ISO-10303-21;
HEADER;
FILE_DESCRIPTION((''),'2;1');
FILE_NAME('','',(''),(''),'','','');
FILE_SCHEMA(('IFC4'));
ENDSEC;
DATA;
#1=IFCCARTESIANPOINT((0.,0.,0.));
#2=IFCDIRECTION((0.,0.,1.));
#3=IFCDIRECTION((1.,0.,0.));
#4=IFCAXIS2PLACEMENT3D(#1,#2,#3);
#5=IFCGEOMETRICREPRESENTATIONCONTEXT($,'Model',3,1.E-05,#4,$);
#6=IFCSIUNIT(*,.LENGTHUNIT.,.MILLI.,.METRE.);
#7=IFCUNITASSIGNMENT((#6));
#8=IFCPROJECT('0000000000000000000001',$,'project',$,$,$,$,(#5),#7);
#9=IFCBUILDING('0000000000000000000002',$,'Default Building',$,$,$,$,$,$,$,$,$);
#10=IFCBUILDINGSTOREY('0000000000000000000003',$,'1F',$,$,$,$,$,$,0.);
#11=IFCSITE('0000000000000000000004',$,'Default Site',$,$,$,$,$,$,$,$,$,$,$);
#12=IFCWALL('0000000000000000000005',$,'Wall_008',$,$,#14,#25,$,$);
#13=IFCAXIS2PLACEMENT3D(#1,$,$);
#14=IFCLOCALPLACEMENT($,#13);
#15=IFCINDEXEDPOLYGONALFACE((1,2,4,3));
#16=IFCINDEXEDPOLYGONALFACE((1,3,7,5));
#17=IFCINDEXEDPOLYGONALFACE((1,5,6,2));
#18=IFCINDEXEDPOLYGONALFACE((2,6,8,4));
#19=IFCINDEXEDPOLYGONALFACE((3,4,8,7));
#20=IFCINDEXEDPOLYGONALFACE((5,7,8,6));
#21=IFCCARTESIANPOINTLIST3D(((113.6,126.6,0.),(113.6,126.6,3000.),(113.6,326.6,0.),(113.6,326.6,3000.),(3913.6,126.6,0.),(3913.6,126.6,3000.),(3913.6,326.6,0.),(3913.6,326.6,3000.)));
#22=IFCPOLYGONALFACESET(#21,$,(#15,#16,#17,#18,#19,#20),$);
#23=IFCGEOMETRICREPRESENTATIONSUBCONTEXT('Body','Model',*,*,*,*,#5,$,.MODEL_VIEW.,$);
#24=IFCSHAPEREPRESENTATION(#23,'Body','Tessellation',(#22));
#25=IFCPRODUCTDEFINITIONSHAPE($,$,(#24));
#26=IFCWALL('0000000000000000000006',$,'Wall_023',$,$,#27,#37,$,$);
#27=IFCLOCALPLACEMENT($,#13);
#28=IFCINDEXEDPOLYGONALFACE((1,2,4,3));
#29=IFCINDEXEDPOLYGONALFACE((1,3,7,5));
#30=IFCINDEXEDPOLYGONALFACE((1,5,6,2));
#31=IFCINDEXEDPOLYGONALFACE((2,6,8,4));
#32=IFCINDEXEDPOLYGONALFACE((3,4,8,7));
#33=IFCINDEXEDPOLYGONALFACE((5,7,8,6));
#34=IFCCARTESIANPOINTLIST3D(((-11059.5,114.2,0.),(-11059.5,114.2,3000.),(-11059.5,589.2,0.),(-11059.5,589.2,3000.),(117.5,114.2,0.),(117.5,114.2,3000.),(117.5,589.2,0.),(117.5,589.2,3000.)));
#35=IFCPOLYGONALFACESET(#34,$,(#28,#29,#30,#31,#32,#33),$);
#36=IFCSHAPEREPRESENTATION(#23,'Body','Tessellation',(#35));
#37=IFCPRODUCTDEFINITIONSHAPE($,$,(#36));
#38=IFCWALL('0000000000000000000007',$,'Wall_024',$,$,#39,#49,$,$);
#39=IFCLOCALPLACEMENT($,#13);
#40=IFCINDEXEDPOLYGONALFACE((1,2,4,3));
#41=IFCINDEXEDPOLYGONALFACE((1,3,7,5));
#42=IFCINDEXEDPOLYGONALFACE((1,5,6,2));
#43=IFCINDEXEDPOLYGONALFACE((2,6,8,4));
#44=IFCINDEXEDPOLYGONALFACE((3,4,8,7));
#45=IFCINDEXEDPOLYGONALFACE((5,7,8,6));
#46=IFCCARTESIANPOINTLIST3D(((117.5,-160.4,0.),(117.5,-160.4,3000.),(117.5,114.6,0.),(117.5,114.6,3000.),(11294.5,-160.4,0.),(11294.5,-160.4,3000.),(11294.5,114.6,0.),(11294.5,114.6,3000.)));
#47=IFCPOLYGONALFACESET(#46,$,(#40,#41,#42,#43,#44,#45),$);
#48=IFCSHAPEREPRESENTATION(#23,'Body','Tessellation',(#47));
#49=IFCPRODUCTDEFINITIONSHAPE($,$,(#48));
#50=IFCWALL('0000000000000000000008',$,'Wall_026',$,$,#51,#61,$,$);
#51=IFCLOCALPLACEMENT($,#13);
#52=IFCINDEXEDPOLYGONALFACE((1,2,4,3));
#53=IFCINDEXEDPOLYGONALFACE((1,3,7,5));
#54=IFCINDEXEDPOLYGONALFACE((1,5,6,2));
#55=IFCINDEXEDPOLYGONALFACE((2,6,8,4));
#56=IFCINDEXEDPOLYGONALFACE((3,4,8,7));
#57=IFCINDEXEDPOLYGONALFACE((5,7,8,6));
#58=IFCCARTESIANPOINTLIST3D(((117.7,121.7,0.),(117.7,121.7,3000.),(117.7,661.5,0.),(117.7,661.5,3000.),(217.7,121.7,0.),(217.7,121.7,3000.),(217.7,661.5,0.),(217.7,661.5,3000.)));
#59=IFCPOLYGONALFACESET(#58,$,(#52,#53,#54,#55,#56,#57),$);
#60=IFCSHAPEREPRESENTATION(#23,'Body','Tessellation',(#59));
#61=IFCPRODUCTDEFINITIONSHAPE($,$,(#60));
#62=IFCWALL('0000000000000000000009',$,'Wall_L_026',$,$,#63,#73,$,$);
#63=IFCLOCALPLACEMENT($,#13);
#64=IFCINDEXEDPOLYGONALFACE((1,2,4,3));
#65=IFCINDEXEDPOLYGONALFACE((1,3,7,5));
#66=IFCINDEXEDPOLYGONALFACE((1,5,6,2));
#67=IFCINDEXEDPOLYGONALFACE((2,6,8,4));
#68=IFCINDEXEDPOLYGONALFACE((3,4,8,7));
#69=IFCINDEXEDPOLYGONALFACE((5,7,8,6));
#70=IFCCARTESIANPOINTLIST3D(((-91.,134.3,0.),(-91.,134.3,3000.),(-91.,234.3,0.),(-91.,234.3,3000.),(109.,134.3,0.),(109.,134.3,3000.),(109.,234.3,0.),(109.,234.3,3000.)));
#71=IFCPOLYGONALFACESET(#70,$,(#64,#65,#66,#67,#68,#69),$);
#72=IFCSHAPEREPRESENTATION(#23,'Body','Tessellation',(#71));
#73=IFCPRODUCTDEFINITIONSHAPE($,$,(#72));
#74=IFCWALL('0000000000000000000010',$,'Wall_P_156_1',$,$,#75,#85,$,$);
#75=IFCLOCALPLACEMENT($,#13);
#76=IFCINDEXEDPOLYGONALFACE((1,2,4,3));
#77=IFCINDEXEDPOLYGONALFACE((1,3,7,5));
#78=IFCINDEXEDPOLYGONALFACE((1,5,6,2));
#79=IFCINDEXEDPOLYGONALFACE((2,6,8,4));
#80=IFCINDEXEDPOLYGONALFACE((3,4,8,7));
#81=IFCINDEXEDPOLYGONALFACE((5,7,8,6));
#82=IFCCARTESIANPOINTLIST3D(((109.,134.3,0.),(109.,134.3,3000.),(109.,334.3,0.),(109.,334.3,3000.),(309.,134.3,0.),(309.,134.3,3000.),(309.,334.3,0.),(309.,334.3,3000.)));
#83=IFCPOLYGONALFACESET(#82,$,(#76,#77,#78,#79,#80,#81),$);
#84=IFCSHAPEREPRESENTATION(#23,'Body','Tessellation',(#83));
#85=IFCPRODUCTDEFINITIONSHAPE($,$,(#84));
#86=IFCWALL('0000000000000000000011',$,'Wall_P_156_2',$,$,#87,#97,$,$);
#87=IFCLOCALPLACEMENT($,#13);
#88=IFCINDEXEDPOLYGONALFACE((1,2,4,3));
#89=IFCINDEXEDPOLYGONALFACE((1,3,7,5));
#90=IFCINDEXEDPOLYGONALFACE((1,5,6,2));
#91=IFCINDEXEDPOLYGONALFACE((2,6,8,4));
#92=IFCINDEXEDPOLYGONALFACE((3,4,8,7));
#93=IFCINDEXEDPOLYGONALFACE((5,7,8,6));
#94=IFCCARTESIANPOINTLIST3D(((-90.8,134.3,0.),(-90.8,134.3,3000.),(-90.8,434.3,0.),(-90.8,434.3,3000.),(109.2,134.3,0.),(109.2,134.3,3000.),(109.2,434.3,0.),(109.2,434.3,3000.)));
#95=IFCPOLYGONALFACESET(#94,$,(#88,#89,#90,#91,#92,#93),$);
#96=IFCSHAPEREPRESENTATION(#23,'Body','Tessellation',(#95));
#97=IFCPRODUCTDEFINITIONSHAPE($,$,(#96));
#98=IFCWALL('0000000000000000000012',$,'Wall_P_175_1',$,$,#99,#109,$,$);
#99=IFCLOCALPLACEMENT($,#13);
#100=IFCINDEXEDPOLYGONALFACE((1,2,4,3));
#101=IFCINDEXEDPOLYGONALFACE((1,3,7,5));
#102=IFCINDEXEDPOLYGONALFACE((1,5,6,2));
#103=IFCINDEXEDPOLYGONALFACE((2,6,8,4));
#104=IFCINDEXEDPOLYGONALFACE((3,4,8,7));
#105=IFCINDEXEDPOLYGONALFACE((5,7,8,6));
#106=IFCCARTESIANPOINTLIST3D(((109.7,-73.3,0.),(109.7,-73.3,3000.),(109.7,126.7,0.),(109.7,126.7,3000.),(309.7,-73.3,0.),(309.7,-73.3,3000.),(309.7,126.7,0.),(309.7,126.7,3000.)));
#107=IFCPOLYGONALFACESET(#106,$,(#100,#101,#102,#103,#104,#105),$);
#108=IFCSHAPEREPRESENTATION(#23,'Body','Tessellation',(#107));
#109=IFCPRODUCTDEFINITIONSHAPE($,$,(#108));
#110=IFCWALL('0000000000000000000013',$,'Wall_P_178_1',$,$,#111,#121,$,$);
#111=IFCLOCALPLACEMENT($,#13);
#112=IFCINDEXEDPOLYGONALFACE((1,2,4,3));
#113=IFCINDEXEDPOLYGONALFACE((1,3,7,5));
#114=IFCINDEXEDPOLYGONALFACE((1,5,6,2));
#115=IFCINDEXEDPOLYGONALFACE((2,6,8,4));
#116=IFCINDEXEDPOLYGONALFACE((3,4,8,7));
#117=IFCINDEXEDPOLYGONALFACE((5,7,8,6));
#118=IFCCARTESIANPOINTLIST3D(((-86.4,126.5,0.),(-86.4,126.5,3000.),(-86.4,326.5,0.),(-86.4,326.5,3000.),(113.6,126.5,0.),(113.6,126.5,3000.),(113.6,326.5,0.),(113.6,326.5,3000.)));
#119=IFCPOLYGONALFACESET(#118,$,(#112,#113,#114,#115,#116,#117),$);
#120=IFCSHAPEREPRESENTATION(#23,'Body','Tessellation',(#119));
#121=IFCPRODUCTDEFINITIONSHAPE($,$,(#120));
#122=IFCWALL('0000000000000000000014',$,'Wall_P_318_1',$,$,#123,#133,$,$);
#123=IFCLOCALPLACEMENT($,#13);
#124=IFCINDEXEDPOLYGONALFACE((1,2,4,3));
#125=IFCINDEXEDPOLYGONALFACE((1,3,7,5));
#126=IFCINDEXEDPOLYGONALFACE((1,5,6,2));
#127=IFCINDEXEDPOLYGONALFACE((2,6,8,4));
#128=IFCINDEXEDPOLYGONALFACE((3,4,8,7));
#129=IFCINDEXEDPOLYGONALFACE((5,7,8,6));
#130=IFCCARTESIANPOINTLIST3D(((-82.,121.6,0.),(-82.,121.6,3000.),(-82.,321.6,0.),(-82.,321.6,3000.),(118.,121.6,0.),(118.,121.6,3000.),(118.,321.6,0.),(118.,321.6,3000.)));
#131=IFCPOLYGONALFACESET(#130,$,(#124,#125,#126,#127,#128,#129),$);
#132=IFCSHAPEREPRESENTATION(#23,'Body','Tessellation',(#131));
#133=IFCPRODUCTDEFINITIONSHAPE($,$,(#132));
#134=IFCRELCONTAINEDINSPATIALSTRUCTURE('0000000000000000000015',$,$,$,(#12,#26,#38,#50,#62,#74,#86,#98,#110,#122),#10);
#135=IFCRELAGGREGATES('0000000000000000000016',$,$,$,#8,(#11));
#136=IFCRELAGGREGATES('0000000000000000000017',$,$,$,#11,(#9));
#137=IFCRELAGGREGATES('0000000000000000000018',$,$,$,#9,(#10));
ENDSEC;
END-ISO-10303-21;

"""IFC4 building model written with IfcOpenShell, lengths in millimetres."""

from ifc_helpers import new_model, si_unit, frame, origin_with_axes, place, context, subcontext, project, spatial, indexed_curve, outline, extrude, element, save


model = new_model("IFC4")

# Units and contexts
model_context = context("Model", 3, precision=1e-05, world=origin_with_axes())
body_context = subcontext(model_context, "Body", "Model", "MODEL_VIEW")
ifc_project = project(units=[si_unit("LENGTHUNIT", "METRE", prefix="MILLI")], contexts=[model_context])

# Site, building, storey
site = spatial("IfcSite", under=ifc_project, Name="Default Site")
building = spatial("IfcBuilding", under=site, Name="Default Building")
storey = spatial("IfcBuildingStorey", under=building, Name="1F", Elevation=0.0)

# Walls
wall_1_placement = place(None, frame((113.6, 126.6, 0.0), z_axis=(0.0, 0.0, 1.0), x_axis=(1.0, 0.0, 0.0)))
element("IfcWall", 1, at=wall_1_placement, inside=storey, Name="Wall_008", context=body_context, shape_type="SweptSolid", body=[
    extrude(outline(indexed_curve([(0.0, 0.0), (0.0, 200.0), (3800.0, 200.0), (3800.0, 0.0), (0.0, 0.0)], self_intersect=False)), origin_with_axes(), (0.0, 0.0, 1.0), 3000.0),
])
wall_2_placement = place(None, frame((117.5, 114.2, 0.0), z_axis=(0.0, 0.0, 1.0), x_axis=(0.0, 1.0, 0.0)))
element("IfcWall", 2, at=wall_2_placement, inside=storey, Name="Wall_023", context=body_context, shape_type="SweptSolid", body=[
    extrude(outline(indexed_curve([(0.0, 0.0), (0.0, 11177.0), (475.0, 11177.0), (475.0, 0.0), (0.0, 0.0)], self_intersect=False)), origin_with_axes(), (0.0, 0.0, 1.0), 3000.0),
])
wall_3_placement = place(None, frame((117.5, 114.6, 0.0), z_axis=(0.0, 0.0, 1.0), x_axis=(0.0, -1.0, 0.0)))
element("IfcWall", 3, at=wall_3_placement, inside=storey, Name="Wall_024", context=body_context, shape_type="SweptSolid", body=[
    extrude(outline(indexed_curve([(0.0, 0.0), (0.0, 11177.0), (275.0, 11177.0), (275.0, 0.0), (0.0, 0.0)], self_intersect=False)), origin_with_axes(), (0.0, 0.0, 1.0), 3000.0),
])
wall_4_placement = place(None, frame((117.7, 121.7, 0.0), z_axis=(0.0, 0.0, 1.0), x_axis=(1.0, 0.0, 0.0)))
element("IfcWall", 4, at=wall_4_placement, inside=storey, Name="Wall_026", context=body_context, shape_type="SweptSolid", body=[
    extrude(outline(indexed_curve([(0.0, 0.0), (0.0, 539.8), (100.0, 539.8), (100.0, 0.0), (0.0, 0.0)], self_intersect=False)), origin_with_axes(), (0.0, 0.0, 1.0), 3000.0),
])
wall_5_placement = place(None, frame((109.0, 134.3, 0.0), z_axis=(0.0, 0.0, 1.0), x_axis=(0.0, 1.0, 0.0)))
element("IfcWall", 5, at=wall_5_placement, inside=storey, Name="Wall_L_026", context=body_context, shape_type="SweptSolid", body=[
    extrude(outline(indexed_curve([(0.0, 0.0), (0.0, 200.0), (100.0, 200.0), (100.0, 0.0), (0.0, 0.0)], self_intersect=False)), origin_with_axes(), (0.0, 0.0, 1.0), 3000.0),
])
wall_6_placement = place(None, frame((109.0, 134.3, 0.0), z_axis=(0.0, 0.0, 1.0), x_axis=(1.0, 0.0, 0.0)))
element("IfcWall", 6, at=wall_6_placement, inside=storey, Name="Wall_P_156_1", context=body_context, shape_type="SweptSolid", body=[
    extrude(outline(indexed_curve([(0.0, 0.0), (0.0, 200.0), (200.0, 200.0), (200.0, 0.0), (0.0, 0.0)], self_intersect=False)), origin_with_axes(), (0.0, 0.0, 1.0), 3000.0),
])
wall_7_placement = place(None, frame((109.2, 134.3, 0.0), z_axis=(0.0, 0.0, 1.0), x_axis=(0.0, 1.0, 0.0)))
element("IfcWall", 7, at=wall_7_placement, inside=storey, Name="Wall_P_156_2", context=body_context, shape_type="SweptSolid", body=[
    extrude(outline(indexed_curve([(0.0, 0.0), (0.0, 200.0), (300.0, 200.0), (300.0, 0.0), (0.0, 0.0)], self_intersect=False)), origin_with_axes(), (0.0, 0.0, 1.0), 3000.0),
])
wall_8_placement = place(None, frame((109.7, 126.7, 0.0), z_axis=(0.0, 0.0, 1.0), x_axis=(0.0, -1.0, 0.0)))
element("IfcWall", 8, at=wall_8_placement, inside=storey, Name="Wall_P_175_1", context=body_context, shape_type="SweptSolid", body=[
    extrude(outline(indexed_curve([(0.0, 0.0), (0.0, 200.0), (200.0, 200.0), (200.0, 0.0), (0.0, 0.0)], self_intersect=False)), origin_with_axes(), (0.0, 0.0, 1.0), 3000.0),
])
wall_9_placement = place(None, frame((113.6, 126.5, 0.0), z_axis=(0.0, 0.0, 1.0), x_axis=(0.0, 1.0, 0.0)))
element("IfcWall", 9, at=wall_9_placement, inside=storey, Name="Wall_P_178_1", context=body_context, shape_type="SweptSolid", body=[
    extrude(outline(indexed_curve([(0.0, 0.0), (0.0, 200.0), (200.0, 200.0), (200.0, 0.0), (0.0, 0.0)], self_intersect=False)), origin_with_axes(), (0.0, 0.0, 1.0), 3000.0),
])
wall_10_placement = place(None, frame((118.0, 121.6, 0.0), z_axis=(0.0, 0.0, 1.0), x_axis=(0.0, 1.0, 0.0)))
element("IfcWall", 10, at=wall_10_placement, inside=storey, Name="Wall_P_318_1", context=body_context, shape_type="SweptSolid", body=[
    extrude(outline(indexed_curve([(0.0, 0.0), (0.0, 200.0), (200.0, 200.0), (200.0, 0.0), (0.0, 0.0)], self_intersect=False)), origin_with_axes(), (0.0, 0.0, 1.0), 3000.0),
])

save(model, "model.ifc")
